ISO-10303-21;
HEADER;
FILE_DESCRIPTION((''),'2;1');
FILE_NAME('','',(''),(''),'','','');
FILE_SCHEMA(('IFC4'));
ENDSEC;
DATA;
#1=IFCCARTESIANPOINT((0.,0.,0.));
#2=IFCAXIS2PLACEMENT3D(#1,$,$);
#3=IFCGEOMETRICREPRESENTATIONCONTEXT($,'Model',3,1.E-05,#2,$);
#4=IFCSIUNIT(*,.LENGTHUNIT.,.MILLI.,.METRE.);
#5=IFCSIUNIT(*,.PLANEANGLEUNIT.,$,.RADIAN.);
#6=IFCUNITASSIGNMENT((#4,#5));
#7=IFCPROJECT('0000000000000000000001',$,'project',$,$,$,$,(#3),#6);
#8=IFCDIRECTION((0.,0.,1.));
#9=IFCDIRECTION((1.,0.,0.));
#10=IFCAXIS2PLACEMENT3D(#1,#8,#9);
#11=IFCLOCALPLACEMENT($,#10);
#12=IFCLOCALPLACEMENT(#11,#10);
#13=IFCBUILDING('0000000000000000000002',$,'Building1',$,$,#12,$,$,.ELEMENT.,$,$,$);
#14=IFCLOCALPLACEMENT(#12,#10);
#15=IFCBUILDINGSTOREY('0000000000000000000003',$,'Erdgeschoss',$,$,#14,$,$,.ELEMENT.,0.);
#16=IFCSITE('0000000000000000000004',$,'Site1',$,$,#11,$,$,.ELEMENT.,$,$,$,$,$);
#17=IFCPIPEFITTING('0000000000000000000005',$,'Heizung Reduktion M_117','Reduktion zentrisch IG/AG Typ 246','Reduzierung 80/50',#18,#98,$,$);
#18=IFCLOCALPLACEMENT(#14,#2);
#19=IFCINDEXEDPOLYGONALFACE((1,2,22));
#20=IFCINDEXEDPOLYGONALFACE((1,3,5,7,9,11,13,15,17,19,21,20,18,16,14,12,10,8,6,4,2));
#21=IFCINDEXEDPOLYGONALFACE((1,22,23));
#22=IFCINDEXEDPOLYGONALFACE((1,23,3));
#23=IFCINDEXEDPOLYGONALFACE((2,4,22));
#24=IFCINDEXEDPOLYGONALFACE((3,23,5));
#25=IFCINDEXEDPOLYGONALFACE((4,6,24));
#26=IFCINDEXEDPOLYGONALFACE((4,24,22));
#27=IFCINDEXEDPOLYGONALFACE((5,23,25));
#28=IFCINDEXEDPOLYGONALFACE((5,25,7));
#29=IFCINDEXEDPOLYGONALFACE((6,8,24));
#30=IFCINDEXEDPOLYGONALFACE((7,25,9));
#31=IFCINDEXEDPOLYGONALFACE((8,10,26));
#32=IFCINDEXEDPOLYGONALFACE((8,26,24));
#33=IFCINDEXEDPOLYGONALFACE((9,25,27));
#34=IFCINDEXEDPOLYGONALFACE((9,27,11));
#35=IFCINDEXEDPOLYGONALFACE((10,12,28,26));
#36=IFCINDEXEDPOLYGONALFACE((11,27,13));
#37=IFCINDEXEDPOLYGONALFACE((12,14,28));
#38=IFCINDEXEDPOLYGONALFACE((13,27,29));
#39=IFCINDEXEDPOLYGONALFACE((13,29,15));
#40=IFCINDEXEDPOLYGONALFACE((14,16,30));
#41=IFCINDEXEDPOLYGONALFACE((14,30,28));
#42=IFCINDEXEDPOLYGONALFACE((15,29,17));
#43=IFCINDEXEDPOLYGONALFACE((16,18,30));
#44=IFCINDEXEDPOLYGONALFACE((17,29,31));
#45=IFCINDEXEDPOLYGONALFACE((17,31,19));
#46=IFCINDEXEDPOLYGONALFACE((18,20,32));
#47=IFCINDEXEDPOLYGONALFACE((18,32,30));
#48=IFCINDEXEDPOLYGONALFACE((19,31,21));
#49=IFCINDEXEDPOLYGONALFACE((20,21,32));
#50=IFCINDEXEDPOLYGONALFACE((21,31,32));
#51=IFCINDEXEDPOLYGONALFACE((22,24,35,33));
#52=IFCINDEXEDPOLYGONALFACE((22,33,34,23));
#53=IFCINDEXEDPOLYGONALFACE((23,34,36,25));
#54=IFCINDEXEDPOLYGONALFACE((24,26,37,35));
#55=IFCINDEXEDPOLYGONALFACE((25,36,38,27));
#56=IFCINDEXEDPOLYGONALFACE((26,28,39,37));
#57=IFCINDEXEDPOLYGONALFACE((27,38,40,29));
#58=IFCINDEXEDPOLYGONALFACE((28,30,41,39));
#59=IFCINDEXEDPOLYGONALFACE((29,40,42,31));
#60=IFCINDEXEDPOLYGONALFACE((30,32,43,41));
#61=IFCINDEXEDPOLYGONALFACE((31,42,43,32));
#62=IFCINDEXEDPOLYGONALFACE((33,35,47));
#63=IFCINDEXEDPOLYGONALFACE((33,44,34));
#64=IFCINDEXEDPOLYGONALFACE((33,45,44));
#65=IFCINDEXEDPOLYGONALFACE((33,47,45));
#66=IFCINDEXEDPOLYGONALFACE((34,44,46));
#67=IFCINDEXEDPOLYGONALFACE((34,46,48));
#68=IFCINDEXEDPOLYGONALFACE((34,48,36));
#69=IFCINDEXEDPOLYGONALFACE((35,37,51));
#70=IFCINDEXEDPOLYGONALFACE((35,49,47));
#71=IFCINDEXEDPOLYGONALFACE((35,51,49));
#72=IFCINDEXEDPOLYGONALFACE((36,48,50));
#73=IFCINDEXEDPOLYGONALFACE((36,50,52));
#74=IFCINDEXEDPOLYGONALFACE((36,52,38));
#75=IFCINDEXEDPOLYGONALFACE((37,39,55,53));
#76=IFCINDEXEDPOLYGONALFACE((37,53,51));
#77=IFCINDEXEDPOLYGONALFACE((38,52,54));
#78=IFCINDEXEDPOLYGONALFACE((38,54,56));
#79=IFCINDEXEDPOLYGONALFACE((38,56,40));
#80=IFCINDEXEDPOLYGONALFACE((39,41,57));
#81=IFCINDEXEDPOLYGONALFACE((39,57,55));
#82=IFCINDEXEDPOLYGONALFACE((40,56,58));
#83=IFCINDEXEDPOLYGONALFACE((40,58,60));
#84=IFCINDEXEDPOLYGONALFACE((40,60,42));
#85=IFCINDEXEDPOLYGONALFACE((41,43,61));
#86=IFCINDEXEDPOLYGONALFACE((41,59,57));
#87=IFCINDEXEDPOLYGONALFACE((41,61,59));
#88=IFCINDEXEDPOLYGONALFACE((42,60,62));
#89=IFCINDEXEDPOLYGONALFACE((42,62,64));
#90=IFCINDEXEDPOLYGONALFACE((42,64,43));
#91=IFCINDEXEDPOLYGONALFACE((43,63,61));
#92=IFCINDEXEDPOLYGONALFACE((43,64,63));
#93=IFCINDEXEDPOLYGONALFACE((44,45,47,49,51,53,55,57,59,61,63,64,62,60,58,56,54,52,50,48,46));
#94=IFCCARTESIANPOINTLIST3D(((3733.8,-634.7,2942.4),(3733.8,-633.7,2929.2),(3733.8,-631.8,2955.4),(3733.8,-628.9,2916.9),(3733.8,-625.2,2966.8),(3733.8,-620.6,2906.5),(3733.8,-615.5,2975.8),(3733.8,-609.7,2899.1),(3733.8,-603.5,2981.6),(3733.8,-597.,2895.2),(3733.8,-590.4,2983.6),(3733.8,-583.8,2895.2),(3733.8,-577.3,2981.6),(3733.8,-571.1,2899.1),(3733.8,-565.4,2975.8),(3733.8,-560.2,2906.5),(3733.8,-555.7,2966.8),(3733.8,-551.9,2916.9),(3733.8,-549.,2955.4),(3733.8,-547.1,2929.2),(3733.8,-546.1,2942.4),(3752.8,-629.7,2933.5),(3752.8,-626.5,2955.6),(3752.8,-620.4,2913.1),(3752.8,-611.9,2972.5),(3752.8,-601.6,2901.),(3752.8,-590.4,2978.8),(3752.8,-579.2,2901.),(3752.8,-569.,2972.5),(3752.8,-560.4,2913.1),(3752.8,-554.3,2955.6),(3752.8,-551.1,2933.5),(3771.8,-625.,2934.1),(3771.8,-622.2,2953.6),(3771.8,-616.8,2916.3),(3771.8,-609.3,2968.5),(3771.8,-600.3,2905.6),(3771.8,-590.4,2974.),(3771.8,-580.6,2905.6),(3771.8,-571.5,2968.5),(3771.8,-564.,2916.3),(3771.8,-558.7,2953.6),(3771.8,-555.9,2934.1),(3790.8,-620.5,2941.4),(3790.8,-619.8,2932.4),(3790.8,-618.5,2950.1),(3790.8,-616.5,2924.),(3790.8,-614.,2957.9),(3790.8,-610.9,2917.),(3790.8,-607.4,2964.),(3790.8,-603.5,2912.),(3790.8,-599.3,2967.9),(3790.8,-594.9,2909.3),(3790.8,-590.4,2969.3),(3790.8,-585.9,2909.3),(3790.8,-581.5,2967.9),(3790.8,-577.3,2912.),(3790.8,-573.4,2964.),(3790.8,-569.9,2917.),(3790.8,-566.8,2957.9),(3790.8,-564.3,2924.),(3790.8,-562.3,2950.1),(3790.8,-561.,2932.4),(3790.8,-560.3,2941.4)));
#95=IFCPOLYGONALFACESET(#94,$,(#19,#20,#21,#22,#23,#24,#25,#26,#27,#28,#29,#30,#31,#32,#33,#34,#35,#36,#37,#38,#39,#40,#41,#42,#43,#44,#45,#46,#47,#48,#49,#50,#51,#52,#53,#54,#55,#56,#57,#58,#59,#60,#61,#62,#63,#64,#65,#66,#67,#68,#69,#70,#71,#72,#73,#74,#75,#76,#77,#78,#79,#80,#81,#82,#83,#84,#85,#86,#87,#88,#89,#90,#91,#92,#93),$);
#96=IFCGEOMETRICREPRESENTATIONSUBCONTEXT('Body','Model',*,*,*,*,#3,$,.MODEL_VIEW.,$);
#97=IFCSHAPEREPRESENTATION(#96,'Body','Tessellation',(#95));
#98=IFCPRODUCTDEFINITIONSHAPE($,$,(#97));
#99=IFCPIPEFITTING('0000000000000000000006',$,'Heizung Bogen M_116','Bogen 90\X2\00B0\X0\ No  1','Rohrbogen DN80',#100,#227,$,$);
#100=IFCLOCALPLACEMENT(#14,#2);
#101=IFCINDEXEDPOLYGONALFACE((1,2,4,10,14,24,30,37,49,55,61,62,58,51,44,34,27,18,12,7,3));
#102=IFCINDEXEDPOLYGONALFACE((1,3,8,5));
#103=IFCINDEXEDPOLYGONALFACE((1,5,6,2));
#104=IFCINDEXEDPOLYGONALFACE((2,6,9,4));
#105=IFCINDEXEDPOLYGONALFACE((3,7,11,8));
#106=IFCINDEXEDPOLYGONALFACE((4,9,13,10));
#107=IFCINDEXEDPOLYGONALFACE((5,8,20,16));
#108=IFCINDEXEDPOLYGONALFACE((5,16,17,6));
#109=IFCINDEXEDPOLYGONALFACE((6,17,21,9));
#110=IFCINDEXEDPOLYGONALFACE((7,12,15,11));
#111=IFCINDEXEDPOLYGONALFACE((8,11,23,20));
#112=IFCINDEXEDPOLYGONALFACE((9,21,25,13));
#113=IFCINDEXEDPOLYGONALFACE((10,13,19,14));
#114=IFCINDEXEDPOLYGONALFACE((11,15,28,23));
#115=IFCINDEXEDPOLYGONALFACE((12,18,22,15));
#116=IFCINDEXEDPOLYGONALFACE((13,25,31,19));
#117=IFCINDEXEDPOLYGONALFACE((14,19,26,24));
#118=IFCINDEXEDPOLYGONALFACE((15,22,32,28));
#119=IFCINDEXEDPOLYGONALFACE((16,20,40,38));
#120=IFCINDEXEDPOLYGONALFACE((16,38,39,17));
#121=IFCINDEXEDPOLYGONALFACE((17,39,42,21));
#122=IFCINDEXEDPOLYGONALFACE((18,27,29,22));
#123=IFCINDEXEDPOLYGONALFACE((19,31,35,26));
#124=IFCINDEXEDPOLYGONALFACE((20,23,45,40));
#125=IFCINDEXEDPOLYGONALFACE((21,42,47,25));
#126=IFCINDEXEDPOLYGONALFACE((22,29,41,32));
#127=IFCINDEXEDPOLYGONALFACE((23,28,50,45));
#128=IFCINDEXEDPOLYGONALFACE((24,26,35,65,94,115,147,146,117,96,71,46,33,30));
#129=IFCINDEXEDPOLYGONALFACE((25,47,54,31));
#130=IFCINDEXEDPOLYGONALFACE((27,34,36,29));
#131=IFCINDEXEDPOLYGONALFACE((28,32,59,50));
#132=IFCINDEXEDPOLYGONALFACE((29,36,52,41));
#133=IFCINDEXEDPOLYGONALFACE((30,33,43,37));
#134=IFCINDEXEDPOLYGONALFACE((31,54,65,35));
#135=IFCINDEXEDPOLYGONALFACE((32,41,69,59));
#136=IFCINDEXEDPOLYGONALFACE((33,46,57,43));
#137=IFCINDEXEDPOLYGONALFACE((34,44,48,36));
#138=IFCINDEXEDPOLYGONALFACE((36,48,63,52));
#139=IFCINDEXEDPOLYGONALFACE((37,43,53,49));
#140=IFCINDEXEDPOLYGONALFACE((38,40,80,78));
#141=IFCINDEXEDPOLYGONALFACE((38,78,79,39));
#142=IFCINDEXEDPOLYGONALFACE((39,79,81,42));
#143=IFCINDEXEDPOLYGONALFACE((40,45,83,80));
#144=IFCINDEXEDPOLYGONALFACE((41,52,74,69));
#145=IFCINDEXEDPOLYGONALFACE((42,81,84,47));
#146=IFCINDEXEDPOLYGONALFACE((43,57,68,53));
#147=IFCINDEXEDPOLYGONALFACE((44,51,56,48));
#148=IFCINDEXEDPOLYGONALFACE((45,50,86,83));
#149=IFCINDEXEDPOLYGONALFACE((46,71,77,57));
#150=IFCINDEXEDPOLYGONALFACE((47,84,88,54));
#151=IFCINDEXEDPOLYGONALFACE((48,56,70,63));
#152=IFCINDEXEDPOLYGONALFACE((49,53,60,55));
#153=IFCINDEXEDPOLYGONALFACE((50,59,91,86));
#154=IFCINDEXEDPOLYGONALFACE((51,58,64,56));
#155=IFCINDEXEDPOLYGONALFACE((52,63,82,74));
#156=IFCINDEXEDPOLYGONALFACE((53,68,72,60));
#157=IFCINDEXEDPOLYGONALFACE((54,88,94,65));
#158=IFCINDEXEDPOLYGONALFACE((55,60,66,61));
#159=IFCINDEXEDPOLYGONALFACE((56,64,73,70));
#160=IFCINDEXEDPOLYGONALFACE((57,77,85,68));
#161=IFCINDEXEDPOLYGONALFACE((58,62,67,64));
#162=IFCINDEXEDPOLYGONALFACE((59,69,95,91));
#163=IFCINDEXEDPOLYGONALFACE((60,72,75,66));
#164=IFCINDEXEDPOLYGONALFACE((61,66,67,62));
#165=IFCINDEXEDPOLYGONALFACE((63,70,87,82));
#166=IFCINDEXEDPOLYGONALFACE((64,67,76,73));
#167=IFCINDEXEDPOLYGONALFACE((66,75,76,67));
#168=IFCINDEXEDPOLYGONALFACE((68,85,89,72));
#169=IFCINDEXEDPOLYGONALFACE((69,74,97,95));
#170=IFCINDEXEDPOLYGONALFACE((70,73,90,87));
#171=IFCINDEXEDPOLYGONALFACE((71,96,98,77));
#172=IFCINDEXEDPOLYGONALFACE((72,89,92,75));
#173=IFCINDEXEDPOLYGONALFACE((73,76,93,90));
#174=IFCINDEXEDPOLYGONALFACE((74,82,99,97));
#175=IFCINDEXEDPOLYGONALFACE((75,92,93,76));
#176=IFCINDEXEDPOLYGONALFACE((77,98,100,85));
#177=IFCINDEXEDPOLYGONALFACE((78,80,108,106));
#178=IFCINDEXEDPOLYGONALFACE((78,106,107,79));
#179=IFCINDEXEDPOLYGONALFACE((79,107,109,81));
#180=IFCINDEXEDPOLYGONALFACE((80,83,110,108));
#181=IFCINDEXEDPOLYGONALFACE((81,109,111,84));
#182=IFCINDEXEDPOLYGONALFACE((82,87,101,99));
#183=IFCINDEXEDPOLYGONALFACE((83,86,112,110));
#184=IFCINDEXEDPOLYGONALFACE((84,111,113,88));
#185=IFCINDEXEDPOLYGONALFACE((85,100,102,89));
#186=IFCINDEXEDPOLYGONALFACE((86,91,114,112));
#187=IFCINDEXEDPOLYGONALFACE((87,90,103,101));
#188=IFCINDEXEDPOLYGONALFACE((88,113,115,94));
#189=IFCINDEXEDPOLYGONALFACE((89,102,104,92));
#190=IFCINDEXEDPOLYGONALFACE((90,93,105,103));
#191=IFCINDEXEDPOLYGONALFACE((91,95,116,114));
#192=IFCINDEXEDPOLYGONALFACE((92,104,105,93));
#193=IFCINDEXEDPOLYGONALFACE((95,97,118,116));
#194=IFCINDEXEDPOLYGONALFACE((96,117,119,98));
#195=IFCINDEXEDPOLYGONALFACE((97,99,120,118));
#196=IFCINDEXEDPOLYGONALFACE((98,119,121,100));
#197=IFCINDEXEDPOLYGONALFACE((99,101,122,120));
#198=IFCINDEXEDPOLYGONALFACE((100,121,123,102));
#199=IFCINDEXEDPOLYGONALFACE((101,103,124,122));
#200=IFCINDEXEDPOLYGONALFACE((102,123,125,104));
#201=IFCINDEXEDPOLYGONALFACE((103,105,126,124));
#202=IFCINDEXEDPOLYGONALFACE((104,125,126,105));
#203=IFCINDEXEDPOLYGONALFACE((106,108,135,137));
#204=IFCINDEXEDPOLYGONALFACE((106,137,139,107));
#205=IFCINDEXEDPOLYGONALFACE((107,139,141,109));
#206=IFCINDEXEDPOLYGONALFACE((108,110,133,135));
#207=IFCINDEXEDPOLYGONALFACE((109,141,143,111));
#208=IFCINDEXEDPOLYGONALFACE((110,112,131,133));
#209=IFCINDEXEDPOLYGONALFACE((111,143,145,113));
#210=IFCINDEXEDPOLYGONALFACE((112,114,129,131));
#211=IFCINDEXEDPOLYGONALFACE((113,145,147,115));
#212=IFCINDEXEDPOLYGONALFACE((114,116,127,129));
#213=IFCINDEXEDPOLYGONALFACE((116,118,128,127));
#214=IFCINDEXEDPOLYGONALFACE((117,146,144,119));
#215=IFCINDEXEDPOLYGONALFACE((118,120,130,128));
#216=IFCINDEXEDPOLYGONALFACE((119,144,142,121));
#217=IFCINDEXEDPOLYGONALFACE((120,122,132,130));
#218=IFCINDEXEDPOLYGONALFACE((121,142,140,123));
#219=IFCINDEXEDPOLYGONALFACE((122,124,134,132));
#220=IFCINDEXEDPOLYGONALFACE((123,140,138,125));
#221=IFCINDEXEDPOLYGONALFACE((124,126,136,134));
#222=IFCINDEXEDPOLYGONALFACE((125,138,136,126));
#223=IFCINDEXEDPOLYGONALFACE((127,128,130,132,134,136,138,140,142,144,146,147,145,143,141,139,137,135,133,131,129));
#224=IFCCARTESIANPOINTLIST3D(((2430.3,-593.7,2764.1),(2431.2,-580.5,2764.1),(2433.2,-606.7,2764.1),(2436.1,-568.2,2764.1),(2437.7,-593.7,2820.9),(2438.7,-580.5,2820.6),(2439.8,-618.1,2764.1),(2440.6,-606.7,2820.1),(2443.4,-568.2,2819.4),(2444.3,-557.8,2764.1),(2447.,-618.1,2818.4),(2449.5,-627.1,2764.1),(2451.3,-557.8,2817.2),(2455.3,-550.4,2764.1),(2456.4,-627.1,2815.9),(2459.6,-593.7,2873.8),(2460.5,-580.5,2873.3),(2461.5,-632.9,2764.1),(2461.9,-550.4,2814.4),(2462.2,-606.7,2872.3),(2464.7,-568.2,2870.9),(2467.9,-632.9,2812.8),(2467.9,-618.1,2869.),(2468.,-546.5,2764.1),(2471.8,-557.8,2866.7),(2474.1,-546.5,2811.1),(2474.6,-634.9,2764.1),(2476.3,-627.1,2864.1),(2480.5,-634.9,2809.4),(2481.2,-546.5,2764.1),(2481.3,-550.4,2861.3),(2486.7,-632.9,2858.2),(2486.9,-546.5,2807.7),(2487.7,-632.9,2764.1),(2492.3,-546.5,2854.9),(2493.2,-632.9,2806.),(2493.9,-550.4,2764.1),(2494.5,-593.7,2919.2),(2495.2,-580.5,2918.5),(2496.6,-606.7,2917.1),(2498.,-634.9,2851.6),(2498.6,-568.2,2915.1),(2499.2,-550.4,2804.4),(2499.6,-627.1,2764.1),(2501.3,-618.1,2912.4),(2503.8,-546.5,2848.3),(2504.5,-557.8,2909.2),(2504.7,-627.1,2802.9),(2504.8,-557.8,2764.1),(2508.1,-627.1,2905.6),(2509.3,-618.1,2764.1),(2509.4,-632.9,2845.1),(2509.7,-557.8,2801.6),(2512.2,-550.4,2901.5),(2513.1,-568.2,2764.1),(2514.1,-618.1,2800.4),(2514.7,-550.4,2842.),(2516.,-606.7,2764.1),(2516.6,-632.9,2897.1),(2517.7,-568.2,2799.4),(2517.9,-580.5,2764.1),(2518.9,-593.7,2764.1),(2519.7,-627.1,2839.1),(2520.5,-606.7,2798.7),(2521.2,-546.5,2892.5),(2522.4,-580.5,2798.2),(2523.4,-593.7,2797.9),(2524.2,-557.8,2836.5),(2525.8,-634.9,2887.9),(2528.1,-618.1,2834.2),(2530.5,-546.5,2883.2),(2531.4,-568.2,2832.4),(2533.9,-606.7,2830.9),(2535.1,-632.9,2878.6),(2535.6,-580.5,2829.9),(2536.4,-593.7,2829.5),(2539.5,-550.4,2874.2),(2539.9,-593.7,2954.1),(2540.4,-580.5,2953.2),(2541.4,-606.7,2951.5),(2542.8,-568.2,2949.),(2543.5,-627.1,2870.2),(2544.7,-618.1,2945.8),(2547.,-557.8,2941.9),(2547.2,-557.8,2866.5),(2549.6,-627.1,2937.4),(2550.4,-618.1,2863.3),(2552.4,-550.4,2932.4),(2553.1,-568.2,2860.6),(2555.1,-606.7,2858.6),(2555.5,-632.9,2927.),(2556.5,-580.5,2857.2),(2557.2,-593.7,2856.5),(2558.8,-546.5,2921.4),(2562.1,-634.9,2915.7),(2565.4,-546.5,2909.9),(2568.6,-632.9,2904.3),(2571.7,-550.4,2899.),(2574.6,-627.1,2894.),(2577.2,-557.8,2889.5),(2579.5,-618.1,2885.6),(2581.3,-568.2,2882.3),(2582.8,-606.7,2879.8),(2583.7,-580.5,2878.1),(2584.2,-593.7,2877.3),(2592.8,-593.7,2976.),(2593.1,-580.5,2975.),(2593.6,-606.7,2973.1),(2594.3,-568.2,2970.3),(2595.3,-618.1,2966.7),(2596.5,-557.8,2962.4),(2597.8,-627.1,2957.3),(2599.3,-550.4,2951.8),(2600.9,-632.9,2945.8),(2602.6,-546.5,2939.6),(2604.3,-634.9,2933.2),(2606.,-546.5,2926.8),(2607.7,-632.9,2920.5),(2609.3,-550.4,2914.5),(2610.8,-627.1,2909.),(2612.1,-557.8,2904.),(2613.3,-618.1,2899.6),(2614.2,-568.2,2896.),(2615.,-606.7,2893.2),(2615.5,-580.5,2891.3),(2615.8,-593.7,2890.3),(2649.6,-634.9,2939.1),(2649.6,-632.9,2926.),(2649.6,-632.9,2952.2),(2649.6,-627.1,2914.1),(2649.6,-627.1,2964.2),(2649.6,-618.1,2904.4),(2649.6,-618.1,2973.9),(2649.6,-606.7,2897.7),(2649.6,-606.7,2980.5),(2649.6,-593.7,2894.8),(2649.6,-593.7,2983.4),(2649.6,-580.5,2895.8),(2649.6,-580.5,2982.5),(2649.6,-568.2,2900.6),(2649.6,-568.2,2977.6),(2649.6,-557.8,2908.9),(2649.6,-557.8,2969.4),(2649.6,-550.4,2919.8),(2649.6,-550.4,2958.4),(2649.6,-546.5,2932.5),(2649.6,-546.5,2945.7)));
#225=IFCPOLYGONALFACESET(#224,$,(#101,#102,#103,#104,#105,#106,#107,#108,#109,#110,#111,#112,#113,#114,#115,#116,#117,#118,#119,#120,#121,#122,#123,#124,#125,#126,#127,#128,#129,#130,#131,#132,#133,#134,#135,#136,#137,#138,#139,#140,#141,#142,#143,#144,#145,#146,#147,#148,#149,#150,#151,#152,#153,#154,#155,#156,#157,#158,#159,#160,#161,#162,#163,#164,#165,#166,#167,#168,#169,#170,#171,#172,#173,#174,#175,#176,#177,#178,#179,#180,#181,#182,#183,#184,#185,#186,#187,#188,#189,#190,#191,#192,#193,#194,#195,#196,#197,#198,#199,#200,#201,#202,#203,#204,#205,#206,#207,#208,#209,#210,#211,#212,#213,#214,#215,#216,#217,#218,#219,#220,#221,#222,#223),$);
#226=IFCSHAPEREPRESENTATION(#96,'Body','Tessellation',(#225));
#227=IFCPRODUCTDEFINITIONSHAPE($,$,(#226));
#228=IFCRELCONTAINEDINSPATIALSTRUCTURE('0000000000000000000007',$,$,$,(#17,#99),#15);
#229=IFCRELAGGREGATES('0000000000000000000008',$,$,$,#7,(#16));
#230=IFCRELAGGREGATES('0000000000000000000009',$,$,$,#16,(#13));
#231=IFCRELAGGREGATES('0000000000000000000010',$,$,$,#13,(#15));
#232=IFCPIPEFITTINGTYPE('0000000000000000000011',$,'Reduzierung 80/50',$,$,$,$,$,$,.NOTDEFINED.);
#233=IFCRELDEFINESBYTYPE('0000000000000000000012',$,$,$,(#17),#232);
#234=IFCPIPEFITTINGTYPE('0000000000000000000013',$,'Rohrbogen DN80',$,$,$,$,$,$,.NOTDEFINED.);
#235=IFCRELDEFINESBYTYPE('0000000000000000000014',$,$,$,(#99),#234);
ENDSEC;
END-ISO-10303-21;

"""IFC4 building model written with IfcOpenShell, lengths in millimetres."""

from ifc_helpers import new_model, entity, si_unit, frame, origin, origin_with_axes, place, context, subcontext, project, spatial, source, transform, mapped, type_object, element, save


model = new_model("IFC4")

# Units and contexts
model_context = context("Model", 3, precision=1e-05, world=origin())
body_context = subcontext(model_context, "Body", "Model", "MODEL_VIEW")
ifc_project = project(units=[si_unit("LENGTHUNIT", "METRE", prefix="MILLI"), si_unit("PLANEANGLEUNIT", "RADIAN")], contexts=[model_context])

# Site, building, storey
site_placement = place(None, origin_with_axes())
site = spatial("IfcSite", under=ifc_project, at=site_placement, Name="Site1", CompositionType="ELEMENT")
building_placement = place(site_placement, origin_with_axes())
building = spatial("IfcBuilding", under=site, at=building_placement, Name="Building1", CompositionType="ELEMENT")
storey_placement = place(building_placement, origin_with_axes())
storey = spatial("IfcBuildingStorey", under=building, at=storey_placement, Name="Erdgeschoss", CompositionType="ELEMENT", Elevation=0.0)

# Shared definitions
pipe_fitting_type_1 = type_object("IfcPipeFittingType", Name="Rohrbogen DN80", PredefinedType="NOTDEFINED")

# Pipe fittings
pipe_fitting_type_2 = type_object("IfcPipeFittingType", Name="Reduzierung 80/50", PredefinedType="NOTDEFINED")
axis2_placement2_d_1 = entity("IfcAxis2Placement2D", entity("IfcCartesianPoint", [0.0, 0.0]), entity("IfcDirection", [1.0, 0.0]))
shared_shape_1 = source(origin_with_axes(), body_context, "Body", "SolidModel", [
    entity("IfcExtrudedAreaSolidTapered", entity("IfcCircleProfileDef", "AREA", None, axis2_placement2_d_1, 44.5), entity("IfcAxis2Placement3D", entity("IfcCartesianPoint", [-28.5, -0.1, 0.0]), entity("IfcDirection", [1.0, 0.0, 0.0]), entity("IfcDirection", [0.0, 0.0, 1.0])), entity("IfcDirection", [0.0, 0.0, 1.0]), 57.0, entity("IfcCircleProfileDef", "AREA", None, axis2_placement2_d_1, 30.1)),
])
pipe_fitting_1_placement = place(storey_placement, frame((3762.3, -590.3, 2939.1), z_axis=(0.0, 0.0, 1.0), x_axis=(1.0, 0.0, 0.0)))
element("IfcPipeFitting", 1, at=pipe_fitting_1_placement, inside=storey, type_object=pipe_fitting_type_2, Name="Heizung Reduktion M_117", Description="Reduktion zentrisch IG/AG Typ 246", ObjectType="Reduzierung 80/50", context=body_context, shape_type="MappedRepresentation", body=[
    mapped(shared_shape_1, transform((0.0, 0.0, 0.0), x_axis=(1.0, 0.0, 0.0), y_axis=(0.0, 1.0, 0.0), z_axis=(0.0, 0.0, 1.0), scale=1.0)),
])
shared_shape_2 = source(origin_with_axes(), body_context, "Body", "SolidModel", [
    entity("IfcRevolvedAreaSolid", entity("IfcCircleProfileDef", "AREA", None, entity("IfcAxis2Placement2D", entity("IfcCartesianPoint", [0.0, 0.0]), entity("IfcDirection", [1.0, 0.0])), 44.5), entity("IfcAxis2Placement3D", entity("IfcCartesianPoint", [109.7, -65.3, 0.0]), entity("IfcDirection", [-1.0, 0.0, 0.0]), entity("IfcDirection", [0.0, 0.0, 1.0])), entity("IfcAxis1Placement", entity("IfcCartesianPoint", [0.0, 175.0, 0.0]), entity("IfcDirection", [-1.0, 0.0, 0.0])), 1.570796),
])
pipe_fitting_2_placement = place(storey_placement, frame((2539.9, -590.4, 2873.8), z_axis=(0.0, 0.0, 1.0), x_axis=(1.0, 0.0, 0.0)))
element("IfcPipeFitting", 2, at=pipe_fitting_2_placement, inside=storey, type_object=pipe_fitting_type_1, Name="Heizung Bogen M_116", Description="Bogen 90° No  1", ObjectType="Rohrbogen DN80", context=body_context, shape_type="MappedRepresentation", body=[
    mapped(shared_shape_2, transform((0.0, 0.0, 0.0), x_axis=(0.0, 0.0, -1.0), y_axis=(1.0, 0.0, 0.0), z_axis=(0.0, -1.0, 0.0), scale=1.0)),
])

save(model, "model.ifc")
